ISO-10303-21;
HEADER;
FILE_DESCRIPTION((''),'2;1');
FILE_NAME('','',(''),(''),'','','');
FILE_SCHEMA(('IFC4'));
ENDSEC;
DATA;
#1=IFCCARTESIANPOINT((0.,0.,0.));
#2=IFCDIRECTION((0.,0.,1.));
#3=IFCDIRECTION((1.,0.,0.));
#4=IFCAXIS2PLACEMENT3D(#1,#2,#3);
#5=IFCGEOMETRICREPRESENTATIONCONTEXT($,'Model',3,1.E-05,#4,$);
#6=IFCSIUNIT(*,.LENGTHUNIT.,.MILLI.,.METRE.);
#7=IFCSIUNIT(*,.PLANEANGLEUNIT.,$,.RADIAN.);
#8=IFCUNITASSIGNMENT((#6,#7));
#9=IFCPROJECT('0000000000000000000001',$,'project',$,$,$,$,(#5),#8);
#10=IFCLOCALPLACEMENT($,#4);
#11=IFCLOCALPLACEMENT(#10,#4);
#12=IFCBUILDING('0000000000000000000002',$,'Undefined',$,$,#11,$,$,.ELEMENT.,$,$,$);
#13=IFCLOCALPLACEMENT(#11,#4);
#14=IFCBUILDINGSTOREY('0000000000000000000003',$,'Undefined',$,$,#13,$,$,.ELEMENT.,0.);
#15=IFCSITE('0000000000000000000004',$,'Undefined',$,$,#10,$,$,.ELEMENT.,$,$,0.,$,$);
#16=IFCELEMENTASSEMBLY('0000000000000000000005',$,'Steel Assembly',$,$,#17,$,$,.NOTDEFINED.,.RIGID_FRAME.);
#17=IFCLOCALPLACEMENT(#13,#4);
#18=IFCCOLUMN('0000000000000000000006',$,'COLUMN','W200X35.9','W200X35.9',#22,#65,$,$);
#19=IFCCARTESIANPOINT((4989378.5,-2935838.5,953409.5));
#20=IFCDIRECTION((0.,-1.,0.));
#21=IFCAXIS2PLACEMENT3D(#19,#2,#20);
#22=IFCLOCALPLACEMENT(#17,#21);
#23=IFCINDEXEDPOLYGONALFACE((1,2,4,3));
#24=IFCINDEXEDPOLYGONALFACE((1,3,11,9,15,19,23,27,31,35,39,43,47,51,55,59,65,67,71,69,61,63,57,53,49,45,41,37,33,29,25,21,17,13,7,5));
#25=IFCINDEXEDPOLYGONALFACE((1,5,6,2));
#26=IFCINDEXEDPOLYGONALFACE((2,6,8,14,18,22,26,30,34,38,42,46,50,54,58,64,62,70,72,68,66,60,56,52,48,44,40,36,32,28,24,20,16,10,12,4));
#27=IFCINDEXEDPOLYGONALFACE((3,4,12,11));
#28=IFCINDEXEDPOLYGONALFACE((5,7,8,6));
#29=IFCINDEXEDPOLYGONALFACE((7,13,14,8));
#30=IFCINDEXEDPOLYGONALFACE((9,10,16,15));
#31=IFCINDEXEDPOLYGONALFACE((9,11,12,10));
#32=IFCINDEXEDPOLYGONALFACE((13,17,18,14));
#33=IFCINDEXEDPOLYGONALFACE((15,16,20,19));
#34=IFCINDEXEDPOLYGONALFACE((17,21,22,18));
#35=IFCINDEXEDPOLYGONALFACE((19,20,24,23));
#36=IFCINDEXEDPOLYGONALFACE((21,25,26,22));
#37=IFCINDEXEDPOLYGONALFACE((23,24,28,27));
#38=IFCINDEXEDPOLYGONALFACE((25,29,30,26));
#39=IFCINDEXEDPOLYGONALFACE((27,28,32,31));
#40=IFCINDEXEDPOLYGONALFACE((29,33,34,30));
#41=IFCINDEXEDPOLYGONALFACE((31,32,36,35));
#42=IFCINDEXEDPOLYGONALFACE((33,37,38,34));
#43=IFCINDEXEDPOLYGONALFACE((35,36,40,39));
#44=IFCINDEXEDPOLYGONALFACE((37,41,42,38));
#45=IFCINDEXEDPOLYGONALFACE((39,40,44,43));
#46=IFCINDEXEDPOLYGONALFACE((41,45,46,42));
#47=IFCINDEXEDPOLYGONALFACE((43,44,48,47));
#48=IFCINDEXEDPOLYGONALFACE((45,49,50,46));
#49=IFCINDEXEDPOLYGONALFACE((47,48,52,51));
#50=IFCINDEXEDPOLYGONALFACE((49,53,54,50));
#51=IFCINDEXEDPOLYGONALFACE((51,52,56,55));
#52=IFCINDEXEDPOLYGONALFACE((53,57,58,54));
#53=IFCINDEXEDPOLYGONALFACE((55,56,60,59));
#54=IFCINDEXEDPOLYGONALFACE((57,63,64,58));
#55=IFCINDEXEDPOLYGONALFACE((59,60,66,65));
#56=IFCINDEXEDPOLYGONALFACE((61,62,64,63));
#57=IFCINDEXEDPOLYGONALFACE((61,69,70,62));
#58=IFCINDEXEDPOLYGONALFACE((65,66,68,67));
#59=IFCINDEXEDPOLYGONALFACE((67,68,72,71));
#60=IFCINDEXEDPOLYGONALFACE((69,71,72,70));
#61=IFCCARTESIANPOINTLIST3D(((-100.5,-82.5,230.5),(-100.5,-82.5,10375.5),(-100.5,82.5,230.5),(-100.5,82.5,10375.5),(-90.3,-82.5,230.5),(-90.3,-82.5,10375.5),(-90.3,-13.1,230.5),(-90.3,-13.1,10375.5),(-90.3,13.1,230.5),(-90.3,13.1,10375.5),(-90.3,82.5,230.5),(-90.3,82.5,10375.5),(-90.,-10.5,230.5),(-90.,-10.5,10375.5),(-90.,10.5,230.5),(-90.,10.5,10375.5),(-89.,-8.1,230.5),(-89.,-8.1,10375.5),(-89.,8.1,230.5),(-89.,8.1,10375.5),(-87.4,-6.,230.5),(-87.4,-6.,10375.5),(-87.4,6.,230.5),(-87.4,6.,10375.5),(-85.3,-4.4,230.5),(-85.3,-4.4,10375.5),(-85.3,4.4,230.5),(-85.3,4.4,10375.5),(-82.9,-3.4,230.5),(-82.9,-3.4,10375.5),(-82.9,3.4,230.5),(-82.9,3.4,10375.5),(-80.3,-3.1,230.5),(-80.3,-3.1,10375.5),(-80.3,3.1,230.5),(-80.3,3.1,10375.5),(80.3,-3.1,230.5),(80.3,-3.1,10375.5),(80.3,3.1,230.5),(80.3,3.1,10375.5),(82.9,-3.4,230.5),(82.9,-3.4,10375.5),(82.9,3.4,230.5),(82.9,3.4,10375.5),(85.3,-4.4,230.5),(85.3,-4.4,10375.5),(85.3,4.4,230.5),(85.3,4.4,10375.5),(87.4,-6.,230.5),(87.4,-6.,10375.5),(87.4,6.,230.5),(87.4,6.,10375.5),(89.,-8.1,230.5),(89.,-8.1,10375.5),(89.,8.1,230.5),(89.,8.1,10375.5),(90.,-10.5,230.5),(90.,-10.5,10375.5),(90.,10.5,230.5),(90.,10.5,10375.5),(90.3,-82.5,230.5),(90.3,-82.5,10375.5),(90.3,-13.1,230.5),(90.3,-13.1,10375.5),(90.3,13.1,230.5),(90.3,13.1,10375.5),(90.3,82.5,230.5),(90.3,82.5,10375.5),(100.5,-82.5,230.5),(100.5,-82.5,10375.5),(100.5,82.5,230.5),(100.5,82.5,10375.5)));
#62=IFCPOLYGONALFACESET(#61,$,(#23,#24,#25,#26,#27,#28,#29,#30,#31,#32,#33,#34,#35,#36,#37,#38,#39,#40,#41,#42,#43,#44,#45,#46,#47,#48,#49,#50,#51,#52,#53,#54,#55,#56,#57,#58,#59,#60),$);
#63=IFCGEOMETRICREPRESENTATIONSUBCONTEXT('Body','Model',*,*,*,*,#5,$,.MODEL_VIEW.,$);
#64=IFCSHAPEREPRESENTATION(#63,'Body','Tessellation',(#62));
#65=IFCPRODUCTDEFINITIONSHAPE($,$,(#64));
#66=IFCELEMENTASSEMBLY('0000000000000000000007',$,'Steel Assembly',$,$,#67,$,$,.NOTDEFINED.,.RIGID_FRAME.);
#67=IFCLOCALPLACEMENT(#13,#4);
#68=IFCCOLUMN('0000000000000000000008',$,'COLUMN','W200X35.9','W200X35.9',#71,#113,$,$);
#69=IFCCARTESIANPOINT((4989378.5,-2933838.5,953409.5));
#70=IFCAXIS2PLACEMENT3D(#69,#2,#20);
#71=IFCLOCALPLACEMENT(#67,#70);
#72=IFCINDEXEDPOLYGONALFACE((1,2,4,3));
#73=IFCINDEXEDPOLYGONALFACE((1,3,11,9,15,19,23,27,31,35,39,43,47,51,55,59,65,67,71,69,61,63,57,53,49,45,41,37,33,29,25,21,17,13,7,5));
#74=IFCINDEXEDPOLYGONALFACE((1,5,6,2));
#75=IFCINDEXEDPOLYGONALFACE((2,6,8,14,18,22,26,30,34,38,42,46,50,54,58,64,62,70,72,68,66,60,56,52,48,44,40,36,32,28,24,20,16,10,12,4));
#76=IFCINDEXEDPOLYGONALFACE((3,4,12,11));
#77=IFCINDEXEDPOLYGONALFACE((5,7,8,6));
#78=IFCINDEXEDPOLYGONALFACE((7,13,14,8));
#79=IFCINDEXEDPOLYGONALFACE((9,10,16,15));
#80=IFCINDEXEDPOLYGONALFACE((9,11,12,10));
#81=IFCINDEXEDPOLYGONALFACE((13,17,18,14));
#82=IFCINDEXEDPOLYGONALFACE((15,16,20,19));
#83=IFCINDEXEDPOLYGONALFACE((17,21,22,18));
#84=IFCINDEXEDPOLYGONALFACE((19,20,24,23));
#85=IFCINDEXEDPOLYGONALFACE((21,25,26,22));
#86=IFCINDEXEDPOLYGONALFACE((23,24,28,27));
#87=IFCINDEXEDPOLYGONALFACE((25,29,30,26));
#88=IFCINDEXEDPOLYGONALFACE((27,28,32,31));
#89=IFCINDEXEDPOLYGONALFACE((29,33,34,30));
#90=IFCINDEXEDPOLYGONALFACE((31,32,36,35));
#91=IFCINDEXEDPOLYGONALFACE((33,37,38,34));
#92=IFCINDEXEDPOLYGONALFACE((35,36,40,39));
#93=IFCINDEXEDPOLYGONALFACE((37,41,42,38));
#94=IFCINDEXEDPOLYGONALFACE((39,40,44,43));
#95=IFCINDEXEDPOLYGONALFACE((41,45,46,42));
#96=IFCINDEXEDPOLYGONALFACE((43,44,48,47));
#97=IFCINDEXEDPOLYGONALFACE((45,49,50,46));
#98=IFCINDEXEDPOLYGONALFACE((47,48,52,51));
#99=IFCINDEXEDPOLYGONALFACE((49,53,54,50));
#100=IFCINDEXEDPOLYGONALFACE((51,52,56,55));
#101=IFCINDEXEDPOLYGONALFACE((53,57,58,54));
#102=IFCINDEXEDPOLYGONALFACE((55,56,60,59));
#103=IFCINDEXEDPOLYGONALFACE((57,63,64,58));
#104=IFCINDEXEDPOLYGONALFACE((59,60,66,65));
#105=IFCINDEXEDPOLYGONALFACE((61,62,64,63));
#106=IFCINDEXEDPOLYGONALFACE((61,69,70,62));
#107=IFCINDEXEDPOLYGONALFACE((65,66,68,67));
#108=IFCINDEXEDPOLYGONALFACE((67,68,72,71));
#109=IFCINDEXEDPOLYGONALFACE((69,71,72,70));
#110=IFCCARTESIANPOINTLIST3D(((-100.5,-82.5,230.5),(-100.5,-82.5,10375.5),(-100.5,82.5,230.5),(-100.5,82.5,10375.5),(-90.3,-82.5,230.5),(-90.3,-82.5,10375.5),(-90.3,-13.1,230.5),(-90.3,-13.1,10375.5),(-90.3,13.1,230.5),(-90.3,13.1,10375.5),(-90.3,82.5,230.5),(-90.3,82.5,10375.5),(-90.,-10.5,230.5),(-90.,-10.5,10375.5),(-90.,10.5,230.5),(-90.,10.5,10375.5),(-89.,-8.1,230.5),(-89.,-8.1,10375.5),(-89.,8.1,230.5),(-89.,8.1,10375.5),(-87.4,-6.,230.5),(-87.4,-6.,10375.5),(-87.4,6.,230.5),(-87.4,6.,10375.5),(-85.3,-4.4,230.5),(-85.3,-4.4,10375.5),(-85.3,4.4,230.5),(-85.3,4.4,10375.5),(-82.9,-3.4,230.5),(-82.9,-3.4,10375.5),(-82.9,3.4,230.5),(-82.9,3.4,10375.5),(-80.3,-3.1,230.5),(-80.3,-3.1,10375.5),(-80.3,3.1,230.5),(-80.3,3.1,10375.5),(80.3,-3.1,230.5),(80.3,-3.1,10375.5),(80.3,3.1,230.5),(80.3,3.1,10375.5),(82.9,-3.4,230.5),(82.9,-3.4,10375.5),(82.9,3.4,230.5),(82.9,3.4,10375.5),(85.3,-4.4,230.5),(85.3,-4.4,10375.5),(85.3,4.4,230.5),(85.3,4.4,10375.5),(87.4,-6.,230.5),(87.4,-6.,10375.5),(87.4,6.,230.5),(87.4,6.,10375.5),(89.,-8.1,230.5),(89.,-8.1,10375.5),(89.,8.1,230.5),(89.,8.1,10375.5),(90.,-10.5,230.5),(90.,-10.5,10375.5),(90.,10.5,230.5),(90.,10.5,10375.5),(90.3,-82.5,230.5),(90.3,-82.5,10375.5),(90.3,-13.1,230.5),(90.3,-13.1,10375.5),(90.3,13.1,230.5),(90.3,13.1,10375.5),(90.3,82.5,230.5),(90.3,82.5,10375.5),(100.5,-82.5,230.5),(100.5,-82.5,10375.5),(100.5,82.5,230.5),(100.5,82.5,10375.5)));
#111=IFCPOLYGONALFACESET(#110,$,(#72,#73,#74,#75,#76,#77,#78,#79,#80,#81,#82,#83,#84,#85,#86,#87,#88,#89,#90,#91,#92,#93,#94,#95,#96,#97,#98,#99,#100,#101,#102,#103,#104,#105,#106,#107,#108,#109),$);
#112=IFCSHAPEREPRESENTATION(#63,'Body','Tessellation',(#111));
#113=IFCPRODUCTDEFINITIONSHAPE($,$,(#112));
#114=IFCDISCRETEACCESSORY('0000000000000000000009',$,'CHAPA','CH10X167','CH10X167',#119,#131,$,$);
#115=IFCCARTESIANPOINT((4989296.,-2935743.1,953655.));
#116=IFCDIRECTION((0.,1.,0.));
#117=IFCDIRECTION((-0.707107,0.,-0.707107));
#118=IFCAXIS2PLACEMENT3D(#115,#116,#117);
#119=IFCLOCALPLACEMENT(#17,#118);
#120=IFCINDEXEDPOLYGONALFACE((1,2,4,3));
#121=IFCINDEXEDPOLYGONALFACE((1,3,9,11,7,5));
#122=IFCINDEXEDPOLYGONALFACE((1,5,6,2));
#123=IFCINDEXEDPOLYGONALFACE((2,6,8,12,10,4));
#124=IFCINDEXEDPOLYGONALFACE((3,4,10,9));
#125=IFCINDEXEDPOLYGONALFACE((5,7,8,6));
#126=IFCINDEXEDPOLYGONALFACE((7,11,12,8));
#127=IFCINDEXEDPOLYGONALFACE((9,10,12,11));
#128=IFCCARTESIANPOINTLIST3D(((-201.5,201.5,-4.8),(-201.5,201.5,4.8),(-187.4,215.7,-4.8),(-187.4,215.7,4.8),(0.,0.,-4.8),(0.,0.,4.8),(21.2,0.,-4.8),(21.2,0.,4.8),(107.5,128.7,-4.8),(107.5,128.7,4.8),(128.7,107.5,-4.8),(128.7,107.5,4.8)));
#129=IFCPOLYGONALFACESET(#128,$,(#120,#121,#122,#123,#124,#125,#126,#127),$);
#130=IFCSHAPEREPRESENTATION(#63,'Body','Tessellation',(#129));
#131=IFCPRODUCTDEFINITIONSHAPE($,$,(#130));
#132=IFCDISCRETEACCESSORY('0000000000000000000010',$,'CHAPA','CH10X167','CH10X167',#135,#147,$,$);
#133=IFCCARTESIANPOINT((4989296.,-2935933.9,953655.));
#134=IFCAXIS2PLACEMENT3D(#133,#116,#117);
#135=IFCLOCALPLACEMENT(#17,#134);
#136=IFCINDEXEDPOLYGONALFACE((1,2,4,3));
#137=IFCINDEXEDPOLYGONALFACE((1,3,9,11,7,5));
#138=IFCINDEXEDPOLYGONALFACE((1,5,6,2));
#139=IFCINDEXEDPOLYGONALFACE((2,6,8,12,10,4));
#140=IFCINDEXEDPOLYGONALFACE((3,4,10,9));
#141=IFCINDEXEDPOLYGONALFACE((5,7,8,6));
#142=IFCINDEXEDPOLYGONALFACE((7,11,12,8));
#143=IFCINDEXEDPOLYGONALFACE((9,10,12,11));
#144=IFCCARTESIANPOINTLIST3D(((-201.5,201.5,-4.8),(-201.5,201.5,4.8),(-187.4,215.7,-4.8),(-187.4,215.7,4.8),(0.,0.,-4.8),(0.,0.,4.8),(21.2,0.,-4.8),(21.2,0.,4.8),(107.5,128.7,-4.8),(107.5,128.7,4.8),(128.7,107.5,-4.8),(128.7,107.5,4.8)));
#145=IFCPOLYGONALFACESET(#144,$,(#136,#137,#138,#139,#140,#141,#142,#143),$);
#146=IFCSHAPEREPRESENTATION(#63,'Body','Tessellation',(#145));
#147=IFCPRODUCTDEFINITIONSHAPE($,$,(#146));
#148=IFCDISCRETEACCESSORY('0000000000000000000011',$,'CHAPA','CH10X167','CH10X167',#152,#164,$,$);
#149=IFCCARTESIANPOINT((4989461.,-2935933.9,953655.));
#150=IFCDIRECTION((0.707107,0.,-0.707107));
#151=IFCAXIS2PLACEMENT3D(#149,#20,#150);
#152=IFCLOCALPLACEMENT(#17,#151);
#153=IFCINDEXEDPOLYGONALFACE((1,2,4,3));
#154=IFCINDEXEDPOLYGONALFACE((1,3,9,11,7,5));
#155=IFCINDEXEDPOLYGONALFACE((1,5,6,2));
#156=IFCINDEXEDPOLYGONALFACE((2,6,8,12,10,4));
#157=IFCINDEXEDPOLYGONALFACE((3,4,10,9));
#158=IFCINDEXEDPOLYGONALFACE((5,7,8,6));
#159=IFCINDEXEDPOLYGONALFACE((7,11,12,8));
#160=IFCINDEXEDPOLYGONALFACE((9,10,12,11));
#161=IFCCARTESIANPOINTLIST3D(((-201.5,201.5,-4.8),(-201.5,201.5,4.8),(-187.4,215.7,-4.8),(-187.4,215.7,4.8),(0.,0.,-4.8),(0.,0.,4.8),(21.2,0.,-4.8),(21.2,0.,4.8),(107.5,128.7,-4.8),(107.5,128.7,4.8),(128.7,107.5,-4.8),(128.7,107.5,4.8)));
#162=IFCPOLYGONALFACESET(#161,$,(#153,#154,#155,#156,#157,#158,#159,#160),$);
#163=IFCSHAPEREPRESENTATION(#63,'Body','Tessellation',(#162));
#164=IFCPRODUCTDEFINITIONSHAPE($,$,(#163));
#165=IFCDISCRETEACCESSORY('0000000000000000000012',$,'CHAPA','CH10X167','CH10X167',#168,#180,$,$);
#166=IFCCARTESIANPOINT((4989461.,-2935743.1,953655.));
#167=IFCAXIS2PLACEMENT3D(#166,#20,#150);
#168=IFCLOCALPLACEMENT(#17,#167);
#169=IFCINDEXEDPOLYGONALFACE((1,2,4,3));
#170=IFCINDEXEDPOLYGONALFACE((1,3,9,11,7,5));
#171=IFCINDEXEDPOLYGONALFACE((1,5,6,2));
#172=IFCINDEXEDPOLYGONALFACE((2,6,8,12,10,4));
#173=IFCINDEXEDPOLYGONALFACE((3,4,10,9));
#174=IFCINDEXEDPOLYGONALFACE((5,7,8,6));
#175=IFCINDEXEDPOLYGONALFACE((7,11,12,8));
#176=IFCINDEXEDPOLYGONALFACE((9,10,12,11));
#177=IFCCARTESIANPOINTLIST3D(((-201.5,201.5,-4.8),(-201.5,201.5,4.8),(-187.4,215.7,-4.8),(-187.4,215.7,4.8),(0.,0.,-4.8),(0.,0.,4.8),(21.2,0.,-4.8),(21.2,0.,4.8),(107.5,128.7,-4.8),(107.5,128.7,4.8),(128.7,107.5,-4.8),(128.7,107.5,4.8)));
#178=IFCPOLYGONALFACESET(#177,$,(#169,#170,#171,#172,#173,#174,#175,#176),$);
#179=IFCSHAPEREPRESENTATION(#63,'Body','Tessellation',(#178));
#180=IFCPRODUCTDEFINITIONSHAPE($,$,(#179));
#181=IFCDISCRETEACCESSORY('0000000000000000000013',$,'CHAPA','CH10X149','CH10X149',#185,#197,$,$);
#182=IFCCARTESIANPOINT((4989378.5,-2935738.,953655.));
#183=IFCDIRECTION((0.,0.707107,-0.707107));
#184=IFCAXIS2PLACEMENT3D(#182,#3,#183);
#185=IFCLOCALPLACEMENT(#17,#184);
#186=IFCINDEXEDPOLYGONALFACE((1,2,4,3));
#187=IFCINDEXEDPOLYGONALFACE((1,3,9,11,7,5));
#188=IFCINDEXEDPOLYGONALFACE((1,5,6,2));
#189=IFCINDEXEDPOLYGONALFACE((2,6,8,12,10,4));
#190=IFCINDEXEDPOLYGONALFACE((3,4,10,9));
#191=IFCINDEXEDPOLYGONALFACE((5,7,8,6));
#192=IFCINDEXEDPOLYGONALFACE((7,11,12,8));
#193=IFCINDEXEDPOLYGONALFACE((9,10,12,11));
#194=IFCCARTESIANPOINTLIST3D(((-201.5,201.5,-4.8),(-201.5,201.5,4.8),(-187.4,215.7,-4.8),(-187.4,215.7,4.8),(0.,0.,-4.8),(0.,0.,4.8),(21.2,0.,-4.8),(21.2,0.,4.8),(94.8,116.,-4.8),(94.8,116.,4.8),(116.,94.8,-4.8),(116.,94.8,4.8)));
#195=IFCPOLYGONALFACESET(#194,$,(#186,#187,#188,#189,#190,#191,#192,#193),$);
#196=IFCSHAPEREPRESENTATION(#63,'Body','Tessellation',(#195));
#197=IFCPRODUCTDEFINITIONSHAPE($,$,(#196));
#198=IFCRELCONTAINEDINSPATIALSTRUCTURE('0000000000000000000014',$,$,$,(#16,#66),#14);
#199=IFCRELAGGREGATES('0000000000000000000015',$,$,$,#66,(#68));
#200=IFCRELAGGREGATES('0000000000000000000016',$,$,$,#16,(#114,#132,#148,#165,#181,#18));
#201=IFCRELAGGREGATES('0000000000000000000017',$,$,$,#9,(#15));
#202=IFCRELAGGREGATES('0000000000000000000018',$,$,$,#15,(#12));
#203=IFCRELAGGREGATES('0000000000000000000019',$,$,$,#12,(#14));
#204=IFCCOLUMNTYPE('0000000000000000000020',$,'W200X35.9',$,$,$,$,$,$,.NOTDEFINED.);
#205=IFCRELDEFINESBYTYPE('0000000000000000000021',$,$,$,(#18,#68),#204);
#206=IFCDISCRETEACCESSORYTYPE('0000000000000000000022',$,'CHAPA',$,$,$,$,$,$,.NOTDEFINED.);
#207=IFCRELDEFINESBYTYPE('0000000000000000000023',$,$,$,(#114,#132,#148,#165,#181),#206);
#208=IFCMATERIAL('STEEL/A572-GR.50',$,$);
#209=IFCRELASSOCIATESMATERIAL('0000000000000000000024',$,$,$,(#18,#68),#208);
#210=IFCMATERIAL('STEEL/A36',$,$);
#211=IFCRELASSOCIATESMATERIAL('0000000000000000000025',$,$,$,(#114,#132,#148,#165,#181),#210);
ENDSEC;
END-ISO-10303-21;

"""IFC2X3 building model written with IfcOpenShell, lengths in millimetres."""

from ifc_helpers import new_model, si_unit, frame, origin_with_axes, origin_2d_with_axis, place, context, subcontext, project, spatial, polyline, i_section, outline, extrude, clip, halfspace, material, type_object, element, aggregate, save


model = new_model("IFC2X3")

# Units and contexts
model_context = context("Model", 3, precision=1e-05, world=origin_with_axes())
body_context = subcontext(model_context, "Body", "Model", "MODEL_VIEW")
ifc_project = project(units=[si_unit("LENGTHUNIT", "METRE", prefix="MILLI"), si_unit("PLANEANGLEUNIT", "RADIAN")], contexts=[model_context])

# Site, building, storey
site_placement = place(None, origin_with_axes())
site = spatial("IfcSite", under=ifc_project, at=site_placement, Name="Undefined", CompositionType="ELEMENT", RefElevation=0.0)
building_placement = place(site_placement, origin_with_axes())
building = spatial("IfcBuilding", under=site, at=building_placement, Name="Undefined", CompositionType="ELEMENT")
storey_placement = place(building_placement, origin_with_axes())
storey = spatial("IfcBuildingStorey", under=building, at=storey_placement, Name="Undefined", CompositionType="ELEMENT", Elevation=0.0)

# Element assemblies, columns
assembly_1_placement = place(storey_placement, origin_with_axes())
assembly_1 = element("IfcElementAssembly", 1, at=assembly_1_placement, inside=storey, Name="Steel Assembly", AssemblyPlace="NOTDEFINED", PredefinedType="RIGID_FRAME")
ifc_material_1 = material(Name="STEEL/A572-GR.50")
column_type = type_object("IfcColumnType", Name="W200X35.9", PredefinedType="NOTDEFINED")
column_1_placement = place(assembly_1_placement, frame((4989378.5, -2935838.5, 953409.5), z_axis=(0.0, 0.0, 1.0), x_axis=(0.0, -1.0, 0.0)))
column_1 = element("IfcColumn", 2, at=column_1_placement, type_object=column_type, material=ifc_material_1, Name="COLUMN", Description="W200X35.9", ObjectType="W200X35.9", context=body_context, shape_type="Clipping", body=[
    clip(clip(clip(extrude(i_section(OverallWidth=165.0, OverallDepth=201.0, WebThickness=6.2, FlangeThickness=10.2, FilletRadius=10.0, at=origin_2d_with_axis()), frame((0.0, 0.0, 10606.0), z_axis=(0.0, 0.0, -1.0), x_axis=(0.0, 1.0, 0.0)), (0.0, 0.0, 1.0), 10375.5), halfspace(frame((-100.5, -82.5, 230.5), z_axis=(0.0, 0.0, -1.0), x_axis=(1.0, 0.0, 0.0)), False)), halfspace(frame((-100.5, 82.5, 10375.5), z_axis=(0.0, 0.0, 1.0), x_axis=(1.0, 0.0, 0.0)), False)), halfspace(frame((-100.5, 0.0, 230.5), z_axis=(0.0, 0.0, 1.0), x_axis=(0.0, 1.0, 0.0)), True)),
])
assembly_2_placement = place(storey_placement, origin_with_axes())
assembly_2 = element("IfcElementAssembly", 3, at=assembly_2_placement, inside=storey, Name="Steel Assembly", AssemblyPlace="NOTDEFINED", PredefinedType="RIGID_FRAME")
column_2_placement = place(assembly_2_placement, frame((4989378.5, -2933838.5, 953409.5), z_axis=(0.0, 0.0, 1.0), x_axis=(0.0, -1.0, 0.0)))
column_2 = element("IfcColumn", 4, at=column_2_placement, type_object=column_type, material=ifc_material_1, Name="COLUMN", Description="W200X35.9", ObjectType="W200X35.9", context=body_context, shape_type="Clipping", body=[
    clip(clip(clip(clip(extrude(i_section(OverallWidth=165.0, OverallDepth=201.0, WebThickness=6.2, FlangeThickness=10.2, FilletRadius=10.0, at=origin_2d_with_axis()), frame((0.0, 0.0, 10606.0), z_axis=(0.0, 0.0, -1.0), x_axis=(0.0, 1.0, 0.0)), (0.0, 0.0, 1.0), 10375.5), halfspace(frame((-100.5, 82.5, 10375.5), z_axis=(0.0, 0.0, 1.0), x_axis=(1.0, 0.0, 0.0)), False)), halfspace(frame((-100.5, 82.5, 10375.5), z_axis=(0.0, 0.0, 1.0), x_axis=(1.0, 0.0, 0.0)), False)), halfspace(frame((-100.5, -82.5, 230.5), z_axis=(0.0, 0.0, -1.0), x_axis=(1.0, 0.0, 0.0)), False)), halfspace(frame((-100.5, 0.0, 230.5), z_axis=(0.0, 0.0, 1.0), x_axis=(0.0, 1.0, 0.0)), True)),
])

# Discrete accessories
ifc_material_2 = material(Name="STEEL/A36")
discrete_accessory_type_1 = type_object("IfcDiscreteAccessoryType", Name="CHAPA")
discrete_accessory_1_placement = place(assembly_1_placement, frame((4989296.0, -2935743.1, 953655.0), z_axis=(0.0, 1.0, 0.0), x_axis=(-0.707107, 0.0, -0.707107)))
discrete_accessory_1 = element("IfcDiscreteAccessory", 5, at=discrete_accessory_1_placement, type_object=discrete_accessory_type_1, material=ifc_material_2, Name="CHAPA", Description="CH10X167", ObjectType="CH10X167", context=body_context, shape_type="SweptSolid", body=[
    extrude(outline(polyline([(0.0, 0.0), (21.2, 0.0), (128.7, 107.5), (107.5, 128.7), (-187.4, 215.7), (-201.5, 201.5), (0.0, 0.0)])), frame((0.0, 0.0, -4.8), z_axis=(0.0, 0.0, 1.0), x_axis=(1.0, 0.0, 0.0)), (0.0, 0.0, 1.0), 9.5),
])
discrete_accessory_2_placement = place(assembly_1_placement, frame((4989296.0, -2935933.9, 953655.0), z_axis=(0.0, 1.0, 0.0), x_axis=(-0.707107, 0.0, -0.707107)))
discrete_accessory_2 = element("IfcDiscreteAccessory", 6, at=discrete_accessory_2_placement, type_object=discrete_accessory_type_1, material=ifc_material_2, Name="CHAPA", Description="CH10X167", ObjectType="CH10X167", context=body_context, shape_type="SweptSolid", body=[
    extrude(outline(polyline([(0.0, 0.0), (21.2, 0.0), (128.7, 107.5), (107.5, 128.7), (-187.4, 215.7), (-201.5, 201.5), (0.0, 0.0)])), frame((0.0, 0.0, -4.8), z_axis=(0.0, 0.0, 1.0), x_axis=(1.0, 0.0, 0.0)), (0.0, 0.0, 1.0), 9.5),
])
discrete_accessory_3_placement = place(assembly_1_placement, frame((4989461.0, -2935933.9, 953655.0), z_axis=(0.0, -1.0, 0.0), x_axis=(0.707107, 0.0, -0.707107)))
discrete_accessory_3 = element("IfcDiscreteAccessory", 7, at=discrete_accessory_3_placement, type_object=discrete_accessory_type_1, material=ifc_material_2, Name="CHAPA", Description="CH10X167", ObjectType="CH10X167", context=body_context, shape_type="SweptSolid", body=[
    extrude(outline(polyline([(0.0, 0.0), (21.2, 0.0), (128.7, 107.5), (107.5, 128.7), (-187.4, 215.7), (-201.5, 201.5), (0.0, 0.0)])), frame((0.0, 0.0, -4.8), z_axis=(0.0, 0.0, 1.0), x_axis=(1.0, 0.0, 0.0)), (0.0, 0.0, 1.0), 9.5),
])
discrete_accessory_4_placement = place(assembly_1_placement, frame((4989461.0, -2935743.1, 953655.0), z_axis=(0.0, -1.0, 0.0), x_axis=(0.707107, 0.0, -0.707107)))
discrete_accessory_4 = element("IfcDiscreteAccessory", 8, at=discrete_accessory_4_placement, type_object=discrete_accessory_type_1, material=ifc_material_2, Name="CHAPA", Description="CH10X167", ObjectType="CH10X167", context=body_context, shape_type="SweptSolid", body=[
    extrude(outline(polyline([(0.0, 0.0), (21.2, 0.0), (128.7, 107.5), (107.5, 128.7), (-187.4, 215.7), (-201.5, 201.5), (0.0, 0.0)])), frame((0.0, 0.0, -4.8), z_axis=(0.0, 0.0, 1.0), x_axis=(1.0, 0.0, 0.0)), (0.0, 0.0, 1.0), 9.5),
])
discrete_accessory_5_placement = place(assembly_1_placement, frame((4989378.5, -2935738.0, 953655.0), z_axis=(1.0, 0.0, 0.0), x_axis=(0.0, 0.707107, -0.707107)))
discrete_accessory_5 = element("IfcDiscreteAccessory", 9, at=discrete_accessory_5_placement, type_object=discrete_accessory_type_1, material=ifc_material_2, Name="CHAPA", Description="CH10X149", ObjectType="CH10X149", context=body_context, shape_type="SweptSolid", body=[
    extrude(outline(polyline([(0.0, 0.0), (21.2, 0.0), (116.0, 94.8), (94.8, 116.0), (-187.4, 215.7), (-201.5, 201.5), (0.0, 0.0)])), frame((0.0, 0.0, -4.8), z_axis=(0.0, 0.0, 1.0), x_axis=(1.0, 0.0, 0.0)), (0.0, 0.0, 1.0), 9.5),
])
aggregate(assembly_2, [column_2])

aggregate(assembly_1, [discrete_accessory_1, discrete_accessory_2, discrete_accessory_3, discrete_accessory_4, discrete_accessory_5, column_1])

save(model, "model.ifc")
